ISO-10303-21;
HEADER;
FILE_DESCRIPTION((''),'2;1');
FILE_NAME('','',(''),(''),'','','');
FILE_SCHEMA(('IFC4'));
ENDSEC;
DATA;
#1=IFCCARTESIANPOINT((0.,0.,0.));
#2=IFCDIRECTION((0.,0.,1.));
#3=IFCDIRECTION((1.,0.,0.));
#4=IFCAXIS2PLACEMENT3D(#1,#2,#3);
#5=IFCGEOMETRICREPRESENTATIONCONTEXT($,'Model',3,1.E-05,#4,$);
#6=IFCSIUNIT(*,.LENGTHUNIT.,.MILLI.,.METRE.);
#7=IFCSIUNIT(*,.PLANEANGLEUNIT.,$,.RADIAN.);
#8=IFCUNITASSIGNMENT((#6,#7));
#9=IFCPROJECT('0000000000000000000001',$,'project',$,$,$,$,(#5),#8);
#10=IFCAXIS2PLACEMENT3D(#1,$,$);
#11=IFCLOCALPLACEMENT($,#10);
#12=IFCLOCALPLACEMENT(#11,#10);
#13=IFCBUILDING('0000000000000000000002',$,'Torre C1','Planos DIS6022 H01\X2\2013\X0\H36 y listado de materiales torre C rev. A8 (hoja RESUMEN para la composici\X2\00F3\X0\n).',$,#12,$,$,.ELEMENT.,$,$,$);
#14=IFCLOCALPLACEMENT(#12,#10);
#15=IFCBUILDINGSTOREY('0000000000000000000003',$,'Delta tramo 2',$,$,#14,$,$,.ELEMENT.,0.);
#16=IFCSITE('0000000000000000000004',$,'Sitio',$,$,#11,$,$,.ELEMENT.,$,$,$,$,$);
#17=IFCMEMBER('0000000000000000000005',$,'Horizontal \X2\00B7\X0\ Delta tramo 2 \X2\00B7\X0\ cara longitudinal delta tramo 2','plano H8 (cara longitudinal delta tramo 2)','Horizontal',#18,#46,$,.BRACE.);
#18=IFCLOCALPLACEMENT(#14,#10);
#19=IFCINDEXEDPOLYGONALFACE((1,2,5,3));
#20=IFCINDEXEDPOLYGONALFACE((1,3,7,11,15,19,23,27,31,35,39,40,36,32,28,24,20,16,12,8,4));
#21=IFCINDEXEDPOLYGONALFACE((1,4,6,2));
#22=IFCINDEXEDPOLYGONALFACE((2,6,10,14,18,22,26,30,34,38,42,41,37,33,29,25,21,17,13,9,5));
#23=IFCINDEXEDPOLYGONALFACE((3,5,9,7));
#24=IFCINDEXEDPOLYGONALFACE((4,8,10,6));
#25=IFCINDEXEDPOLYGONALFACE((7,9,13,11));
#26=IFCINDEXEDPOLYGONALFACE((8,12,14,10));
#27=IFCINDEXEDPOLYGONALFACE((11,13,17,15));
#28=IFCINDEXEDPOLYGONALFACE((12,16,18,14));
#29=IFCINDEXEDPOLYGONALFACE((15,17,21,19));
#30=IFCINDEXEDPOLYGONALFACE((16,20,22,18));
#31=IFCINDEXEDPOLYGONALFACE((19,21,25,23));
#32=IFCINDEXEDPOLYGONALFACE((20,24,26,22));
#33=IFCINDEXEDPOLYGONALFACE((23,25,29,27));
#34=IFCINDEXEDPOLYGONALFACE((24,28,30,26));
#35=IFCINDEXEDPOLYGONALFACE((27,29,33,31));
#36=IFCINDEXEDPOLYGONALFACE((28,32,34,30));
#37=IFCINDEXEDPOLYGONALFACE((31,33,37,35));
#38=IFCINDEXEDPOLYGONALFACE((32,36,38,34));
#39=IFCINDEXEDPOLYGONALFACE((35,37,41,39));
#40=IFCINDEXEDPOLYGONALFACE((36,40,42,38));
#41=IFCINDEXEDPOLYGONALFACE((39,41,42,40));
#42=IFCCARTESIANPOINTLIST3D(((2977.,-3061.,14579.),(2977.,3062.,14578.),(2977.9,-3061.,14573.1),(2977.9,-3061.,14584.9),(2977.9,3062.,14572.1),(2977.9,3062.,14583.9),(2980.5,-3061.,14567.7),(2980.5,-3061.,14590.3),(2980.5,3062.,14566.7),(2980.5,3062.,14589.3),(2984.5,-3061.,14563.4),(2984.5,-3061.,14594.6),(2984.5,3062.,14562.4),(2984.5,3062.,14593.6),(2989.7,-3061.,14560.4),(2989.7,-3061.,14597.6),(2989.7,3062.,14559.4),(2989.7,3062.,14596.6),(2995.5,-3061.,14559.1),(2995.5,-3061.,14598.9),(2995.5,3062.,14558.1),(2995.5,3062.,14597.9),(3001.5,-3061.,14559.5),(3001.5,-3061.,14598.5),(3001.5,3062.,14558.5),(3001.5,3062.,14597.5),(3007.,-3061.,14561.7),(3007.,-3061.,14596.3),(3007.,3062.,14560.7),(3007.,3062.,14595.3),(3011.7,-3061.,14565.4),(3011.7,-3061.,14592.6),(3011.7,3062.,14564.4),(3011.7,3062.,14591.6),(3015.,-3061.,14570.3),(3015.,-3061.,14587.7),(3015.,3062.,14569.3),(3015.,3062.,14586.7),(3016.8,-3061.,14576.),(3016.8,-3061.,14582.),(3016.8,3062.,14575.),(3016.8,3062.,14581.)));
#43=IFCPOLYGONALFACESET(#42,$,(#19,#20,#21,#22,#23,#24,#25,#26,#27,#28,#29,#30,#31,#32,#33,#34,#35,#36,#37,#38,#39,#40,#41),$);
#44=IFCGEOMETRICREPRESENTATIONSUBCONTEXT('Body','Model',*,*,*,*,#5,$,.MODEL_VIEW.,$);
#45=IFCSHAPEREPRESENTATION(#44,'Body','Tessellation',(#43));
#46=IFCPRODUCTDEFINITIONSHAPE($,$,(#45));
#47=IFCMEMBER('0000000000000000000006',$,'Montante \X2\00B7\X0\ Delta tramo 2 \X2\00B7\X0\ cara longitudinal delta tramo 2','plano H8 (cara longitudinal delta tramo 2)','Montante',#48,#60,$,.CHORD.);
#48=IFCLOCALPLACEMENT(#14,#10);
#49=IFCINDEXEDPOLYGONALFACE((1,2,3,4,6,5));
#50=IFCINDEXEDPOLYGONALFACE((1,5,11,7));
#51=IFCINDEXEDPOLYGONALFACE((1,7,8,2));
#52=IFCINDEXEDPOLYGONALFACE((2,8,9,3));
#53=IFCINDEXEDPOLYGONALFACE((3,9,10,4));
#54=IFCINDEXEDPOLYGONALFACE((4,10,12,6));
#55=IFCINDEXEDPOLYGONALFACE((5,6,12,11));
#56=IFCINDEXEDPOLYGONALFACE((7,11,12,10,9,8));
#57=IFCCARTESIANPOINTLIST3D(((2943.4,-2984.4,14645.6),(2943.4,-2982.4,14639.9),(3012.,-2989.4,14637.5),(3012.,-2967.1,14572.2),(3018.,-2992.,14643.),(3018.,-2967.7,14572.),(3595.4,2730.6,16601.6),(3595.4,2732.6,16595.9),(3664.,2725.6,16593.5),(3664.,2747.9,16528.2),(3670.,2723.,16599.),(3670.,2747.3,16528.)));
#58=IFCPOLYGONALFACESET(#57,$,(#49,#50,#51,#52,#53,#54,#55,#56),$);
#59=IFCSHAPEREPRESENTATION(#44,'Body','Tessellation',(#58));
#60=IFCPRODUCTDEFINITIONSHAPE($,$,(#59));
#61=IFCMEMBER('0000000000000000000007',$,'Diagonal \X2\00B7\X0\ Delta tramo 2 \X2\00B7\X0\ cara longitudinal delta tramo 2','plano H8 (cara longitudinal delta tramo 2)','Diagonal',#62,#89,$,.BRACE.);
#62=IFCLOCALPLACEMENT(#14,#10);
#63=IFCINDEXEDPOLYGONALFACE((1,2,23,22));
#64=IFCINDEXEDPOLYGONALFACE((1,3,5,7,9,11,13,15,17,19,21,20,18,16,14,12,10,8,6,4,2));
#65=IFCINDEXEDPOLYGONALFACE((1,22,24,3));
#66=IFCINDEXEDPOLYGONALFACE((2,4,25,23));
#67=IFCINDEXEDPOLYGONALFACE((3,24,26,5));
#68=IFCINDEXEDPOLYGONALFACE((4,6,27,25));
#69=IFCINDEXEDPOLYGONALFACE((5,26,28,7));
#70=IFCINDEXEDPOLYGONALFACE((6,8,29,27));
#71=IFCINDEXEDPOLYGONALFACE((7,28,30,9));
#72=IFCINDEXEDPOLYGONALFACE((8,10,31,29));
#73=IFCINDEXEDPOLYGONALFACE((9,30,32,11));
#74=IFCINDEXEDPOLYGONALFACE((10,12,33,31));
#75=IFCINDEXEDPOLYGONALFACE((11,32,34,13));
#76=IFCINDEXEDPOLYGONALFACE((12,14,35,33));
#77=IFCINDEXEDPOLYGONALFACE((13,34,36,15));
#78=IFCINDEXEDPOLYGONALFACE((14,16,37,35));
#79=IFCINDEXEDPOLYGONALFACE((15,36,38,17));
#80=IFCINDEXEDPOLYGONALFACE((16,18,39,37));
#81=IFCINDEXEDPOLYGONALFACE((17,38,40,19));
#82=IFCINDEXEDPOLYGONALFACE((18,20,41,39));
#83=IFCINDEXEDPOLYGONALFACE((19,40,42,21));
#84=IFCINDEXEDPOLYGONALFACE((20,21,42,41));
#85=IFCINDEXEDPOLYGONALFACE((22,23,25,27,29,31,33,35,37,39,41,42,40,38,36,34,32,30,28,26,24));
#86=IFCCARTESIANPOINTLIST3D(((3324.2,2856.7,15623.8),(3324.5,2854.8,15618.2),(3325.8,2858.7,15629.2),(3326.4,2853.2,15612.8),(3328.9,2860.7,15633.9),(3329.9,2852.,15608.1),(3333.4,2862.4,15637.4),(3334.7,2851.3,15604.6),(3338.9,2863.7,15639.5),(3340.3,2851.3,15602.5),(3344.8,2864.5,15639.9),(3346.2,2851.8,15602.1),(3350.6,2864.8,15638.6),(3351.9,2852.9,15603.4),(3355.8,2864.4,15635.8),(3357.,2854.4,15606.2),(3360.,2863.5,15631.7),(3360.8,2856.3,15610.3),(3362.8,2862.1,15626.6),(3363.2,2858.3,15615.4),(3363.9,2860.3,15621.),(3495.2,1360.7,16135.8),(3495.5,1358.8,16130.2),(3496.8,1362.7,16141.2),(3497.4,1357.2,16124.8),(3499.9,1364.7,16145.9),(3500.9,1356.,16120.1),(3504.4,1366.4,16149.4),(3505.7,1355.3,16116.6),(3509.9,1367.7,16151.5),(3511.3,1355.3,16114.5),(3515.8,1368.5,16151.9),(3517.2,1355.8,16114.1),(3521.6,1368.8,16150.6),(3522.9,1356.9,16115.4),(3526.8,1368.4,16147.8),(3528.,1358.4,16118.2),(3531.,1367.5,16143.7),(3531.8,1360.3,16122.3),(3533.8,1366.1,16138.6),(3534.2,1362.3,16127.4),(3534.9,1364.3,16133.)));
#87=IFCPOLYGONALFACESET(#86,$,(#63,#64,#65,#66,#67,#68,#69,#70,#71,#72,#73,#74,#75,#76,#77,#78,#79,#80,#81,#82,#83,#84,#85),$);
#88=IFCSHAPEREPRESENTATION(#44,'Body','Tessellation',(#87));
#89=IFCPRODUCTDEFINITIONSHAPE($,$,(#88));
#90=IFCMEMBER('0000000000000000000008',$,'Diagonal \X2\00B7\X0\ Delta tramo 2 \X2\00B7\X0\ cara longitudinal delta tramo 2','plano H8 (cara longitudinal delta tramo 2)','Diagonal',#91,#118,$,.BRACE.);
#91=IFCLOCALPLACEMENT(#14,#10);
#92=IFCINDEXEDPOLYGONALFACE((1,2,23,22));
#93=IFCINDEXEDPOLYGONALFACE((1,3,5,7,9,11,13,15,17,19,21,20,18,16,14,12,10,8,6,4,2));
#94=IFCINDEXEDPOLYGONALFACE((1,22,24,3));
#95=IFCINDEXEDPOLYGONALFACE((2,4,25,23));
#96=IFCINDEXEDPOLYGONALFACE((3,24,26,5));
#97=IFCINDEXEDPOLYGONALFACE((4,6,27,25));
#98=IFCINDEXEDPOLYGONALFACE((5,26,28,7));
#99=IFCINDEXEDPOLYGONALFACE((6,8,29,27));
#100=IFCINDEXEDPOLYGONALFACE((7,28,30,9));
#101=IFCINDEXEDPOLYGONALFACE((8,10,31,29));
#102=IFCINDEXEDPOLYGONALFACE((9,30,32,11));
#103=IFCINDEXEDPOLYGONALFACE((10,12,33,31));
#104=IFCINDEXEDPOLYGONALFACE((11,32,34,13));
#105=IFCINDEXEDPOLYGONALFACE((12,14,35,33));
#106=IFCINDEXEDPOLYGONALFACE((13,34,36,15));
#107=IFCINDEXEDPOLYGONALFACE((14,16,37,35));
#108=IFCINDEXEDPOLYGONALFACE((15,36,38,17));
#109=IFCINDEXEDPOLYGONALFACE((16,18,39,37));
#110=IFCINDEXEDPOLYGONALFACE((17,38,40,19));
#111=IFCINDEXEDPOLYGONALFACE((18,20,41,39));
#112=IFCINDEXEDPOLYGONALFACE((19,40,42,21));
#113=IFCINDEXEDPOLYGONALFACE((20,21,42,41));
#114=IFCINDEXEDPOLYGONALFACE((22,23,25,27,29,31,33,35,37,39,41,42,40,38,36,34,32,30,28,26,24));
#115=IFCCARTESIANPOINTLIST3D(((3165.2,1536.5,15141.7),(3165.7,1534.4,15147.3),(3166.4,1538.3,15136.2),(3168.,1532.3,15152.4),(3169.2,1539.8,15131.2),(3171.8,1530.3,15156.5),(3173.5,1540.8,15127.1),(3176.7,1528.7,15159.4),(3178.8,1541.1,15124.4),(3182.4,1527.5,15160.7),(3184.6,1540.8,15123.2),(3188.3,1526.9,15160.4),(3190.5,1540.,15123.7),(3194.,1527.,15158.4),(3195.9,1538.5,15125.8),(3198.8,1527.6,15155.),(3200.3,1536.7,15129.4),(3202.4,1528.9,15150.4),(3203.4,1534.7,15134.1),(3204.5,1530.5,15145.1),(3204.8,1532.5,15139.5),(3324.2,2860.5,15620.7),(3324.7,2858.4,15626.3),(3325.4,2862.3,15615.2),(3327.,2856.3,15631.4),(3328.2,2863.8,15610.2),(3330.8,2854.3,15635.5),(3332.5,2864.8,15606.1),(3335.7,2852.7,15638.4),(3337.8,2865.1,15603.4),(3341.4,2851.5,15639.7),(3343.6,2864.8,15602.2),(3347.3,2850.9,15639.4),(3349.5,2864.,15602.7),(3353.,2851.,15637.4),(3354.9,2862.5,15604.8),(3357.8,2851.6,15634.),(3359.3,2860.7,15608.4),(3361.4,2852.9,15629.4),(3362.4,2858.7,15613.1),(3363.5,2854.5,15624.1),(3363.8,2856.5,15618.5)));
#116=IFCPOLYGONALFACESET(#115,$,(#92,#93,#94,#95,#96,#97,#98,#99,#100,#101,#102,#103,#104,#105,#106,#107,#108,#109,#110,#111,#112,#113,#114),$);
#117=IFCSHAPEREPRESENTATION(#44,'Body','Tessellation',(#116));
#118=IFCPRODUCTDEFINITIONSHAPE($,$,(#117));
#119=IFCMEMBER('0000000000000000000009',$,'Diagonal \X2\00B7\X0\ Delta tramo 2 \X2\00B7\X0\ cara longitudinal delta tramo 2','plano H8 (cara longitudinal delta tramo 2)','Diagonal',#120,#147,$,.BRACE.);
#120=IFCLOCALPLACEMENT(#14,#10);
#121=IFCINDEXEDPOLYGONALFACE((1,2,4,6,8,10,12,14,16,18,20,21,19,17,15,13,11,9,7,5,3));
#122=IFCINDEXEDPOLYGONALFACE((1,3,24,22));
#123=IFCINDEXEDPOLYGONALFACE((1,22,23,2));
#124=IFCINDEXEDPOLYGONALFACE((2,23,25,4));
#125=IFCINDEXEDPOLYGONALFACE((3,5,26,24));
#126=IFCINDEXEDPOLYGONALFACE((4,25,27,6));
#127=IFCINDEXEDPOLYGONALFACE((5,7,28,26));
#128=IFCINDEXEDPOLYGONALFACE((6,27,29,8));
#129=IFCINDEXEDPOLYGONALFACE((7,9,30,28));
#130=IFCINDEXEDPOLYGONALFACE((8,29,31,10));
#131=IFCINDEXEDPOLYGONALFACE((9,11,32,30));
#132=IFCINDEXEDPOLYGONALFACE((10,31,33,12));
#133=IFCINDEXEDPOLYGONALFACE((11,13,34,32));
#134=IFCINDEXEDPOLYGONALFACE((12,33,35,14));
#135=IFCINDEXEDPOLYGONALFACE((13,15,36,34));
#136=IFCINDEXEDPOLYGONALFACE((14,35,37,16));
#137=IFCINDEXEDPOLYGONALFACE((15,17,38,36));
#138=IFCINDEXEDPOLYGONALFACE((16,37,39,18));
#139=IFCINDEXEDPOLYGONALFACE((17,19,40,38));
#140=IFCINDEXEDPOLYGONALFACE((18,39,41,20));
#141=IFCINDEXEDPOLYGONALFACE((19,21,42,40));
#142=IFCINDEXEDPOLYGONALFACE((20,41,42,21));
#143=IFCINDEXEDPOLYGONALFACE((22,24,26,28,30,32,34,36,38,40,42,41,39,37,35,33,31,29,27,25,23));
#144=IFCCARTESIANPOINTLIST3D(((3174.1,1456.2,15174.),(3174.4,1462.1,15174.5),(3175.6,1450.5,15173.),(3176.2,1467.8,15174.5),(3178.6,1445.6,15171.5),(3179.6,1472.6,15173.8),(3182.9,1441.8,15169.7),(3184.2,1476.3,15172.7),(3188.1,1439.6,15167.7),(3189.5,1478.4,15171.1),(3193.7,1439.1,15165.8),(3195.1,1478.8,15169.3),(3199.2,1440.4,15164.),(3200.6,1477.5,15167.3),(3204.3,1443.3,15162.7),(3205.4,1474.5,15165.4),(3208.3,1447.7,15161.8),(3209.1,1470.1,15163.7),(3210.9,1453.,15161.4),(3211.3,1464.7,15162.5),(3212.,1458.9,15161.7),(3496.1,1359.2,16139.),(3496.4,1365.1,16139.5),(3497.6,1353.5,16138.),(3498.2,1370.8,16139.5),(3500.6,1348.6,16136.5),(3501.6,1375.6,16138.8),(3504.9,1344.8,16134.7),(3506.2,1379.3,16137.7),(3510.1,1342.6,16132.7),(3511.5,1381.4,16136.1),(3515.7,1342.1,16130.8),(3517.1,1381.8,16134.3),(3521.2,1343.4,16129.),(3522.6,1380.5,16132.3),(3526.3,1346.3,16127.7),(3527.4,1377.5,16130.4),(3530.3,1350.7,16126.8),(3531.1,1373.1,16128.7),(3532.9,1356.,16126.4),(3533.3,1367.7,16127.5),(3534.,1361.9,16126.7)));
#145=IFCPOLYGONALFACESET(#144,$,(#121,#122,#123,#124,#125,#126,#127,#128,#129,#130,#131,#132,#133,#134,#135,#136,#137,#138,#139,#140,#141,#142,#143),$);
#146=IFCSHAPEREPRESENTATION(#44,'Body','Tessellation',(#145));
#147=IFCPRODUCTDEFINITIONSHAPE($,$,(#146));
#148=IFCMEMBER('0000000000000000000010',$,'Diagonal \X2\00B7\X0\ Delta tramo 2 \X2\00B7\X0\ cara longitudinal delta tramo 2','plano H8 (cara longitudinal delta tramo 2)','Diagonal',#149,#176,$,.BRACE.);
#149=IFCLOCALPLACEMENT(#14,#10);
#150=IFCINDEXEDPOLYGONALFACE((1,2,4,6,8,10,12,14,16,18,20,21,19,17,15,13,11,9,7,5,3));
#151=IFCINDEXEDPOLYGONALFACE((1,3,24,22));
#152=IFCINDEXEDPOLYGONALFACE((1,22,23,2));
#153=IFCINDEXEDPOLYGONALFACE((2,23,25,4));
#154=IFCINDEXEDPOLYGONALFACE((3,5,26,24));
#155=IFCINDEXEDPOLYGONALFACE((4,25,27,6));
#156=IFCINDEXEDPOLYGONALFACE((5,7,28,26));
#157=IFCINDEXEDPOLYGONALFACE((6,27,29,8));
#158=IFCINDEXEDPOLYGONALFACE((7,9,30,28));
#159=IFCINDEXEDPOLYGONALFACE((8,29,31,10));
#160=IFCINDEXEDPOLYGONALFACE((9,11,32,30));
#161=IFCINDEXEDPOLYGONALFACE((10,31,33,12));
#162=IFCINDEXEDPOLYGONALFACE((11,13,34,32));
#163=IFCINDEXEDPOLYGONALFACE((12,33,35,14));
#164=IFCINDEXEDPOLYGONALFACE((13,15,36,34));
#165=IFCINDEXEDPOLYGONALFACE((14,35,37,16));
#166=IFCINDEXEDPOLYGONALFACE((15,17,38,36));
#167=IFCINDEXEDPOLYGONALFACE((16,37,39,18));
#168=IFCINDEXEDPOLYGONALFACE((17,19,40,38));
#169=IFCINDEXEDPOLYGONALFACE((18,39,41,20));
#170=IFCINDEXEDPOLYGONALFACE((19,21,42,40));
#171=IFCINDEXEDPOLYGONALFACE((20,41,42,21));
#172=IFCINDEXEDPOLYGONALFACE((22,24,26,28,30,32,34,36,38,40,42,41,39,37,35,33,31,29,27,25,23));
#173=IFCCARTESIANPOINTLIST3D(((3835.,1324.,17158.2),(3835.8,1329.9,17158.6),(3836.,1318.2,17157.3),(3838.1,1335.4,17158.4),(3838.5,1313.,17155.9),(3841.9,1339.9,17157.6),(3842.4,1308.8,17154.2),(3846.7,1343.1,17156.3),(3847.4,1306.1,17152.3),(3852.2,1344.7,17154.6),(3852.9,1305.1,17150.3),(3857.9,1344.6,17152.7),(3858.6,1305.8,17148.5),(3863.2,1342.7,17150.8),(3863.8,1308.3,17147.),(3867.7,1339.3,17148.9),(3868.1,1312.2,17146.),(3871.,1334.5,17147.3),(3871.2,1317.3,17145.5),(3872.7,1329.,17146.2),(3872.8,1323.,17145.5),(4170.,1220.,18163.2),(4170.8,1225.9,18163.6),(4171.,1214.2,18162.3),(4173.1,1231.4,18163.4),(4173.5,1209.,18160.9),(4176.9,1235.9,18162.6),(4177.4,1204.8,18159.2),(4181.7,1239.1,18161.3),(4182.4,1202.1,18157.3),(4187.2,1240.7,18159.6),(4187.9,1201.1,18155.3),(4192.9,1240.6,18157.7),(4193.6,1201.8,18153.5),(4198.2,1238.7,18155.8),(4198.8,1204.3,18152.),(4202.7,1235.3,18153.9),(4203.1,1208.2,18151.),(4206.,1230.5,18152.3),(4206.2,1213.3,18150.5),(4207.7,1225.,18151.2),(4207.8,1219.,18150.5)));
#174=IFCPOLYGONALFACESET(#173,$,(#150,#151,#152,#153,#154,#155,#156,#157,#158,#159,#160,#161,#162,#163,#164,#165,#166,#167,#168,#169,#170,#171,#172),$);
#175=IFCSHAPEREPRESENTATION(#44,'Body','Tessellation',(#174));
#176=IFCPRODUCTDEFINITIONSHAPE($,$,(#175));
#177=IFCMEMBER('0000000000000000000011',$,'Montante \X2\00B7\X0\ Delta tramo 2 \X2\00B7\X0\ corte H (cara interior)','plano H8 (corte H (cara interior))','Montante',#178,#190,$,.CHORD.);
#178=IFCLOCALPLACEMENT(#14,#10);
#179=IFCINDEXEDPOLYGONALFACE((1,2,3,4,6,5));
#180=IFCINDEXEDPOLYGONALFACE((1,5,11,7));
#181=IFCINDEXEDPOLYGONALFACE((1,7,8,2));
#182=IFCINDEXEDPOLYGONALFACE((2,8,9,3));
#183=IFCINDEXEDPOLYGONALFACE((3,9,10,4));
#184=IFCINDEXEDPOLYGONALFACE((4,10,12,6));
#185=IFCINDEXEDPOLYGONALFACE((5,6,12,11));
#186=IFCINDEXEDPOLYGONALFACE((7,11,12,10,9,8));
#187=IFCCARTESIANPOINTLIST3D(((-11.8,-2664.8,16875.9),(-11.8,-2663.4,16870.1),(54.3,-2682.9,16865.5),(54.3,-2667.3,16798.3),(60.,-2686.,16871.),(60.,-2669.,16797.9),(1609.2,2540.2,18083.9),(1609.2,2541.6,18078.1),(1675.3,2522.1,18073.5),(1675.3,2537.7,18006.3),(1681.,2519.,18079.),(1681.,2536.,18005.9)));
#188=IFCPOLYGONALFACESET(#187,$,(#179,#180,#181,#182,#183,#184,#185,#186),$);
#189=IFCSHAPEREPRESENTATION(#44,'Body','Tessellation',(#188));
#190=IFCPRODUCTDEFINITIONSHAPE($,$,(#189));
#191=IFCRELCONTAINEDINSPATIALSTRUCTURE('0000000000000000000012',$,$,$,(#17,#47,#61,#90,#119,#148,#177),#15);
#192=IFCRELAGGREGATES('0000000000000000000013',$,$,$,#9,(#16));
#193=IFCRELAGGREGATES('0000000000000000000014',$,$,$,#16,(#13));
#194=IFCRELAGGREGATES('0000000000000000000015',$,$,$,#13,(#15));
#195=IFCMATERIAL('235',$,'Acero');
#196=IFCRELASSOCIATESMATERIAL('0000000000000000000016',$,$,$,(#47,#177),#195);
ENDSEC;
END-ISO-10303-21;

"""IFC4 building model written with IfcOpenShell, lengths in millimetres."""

from ifc_helpers import new_model, si_unit, frame, frame_2d, origin, origin_with_axes, place, context, subcontext, project, spatial, circle, l_section, extrude, material, element, save


model = new_model("IFC4")

# Units and contexts
model_context = context("Model", 3, precision=1e-05, world=origin_with_axes())
body_context = subcontext(model_context, "Body", "Model", "MODEL_VIEW")
ifc_project = project(units=[si_unit("LENGTHUNIT", "METRE", prefix="MILLI"), si_unit("PLANEANGLEUNIT", "RADIAN")], contexts=[model_context])

# Site, building, storey
site_placement = place(None, origin())
site = spatial("IfcSite", under=ifc_project, at=site_placement, Name="Sitio", CompositionType="ELEMENT")
building_placement = place(site_placement, origin())
building = spatial("IfcBuilding", under=site, at=building_placement, Name="Torre C1", Description="Planos DIS6022 H01–H36 y listado de materiales torre C rev. A8 (hoja RESUMEN para la composición).", CompositionType="ELEMENT")
storey_placement = place(building_placement, origin())
storey = spatial("IfcBuildingStorey", under=building, at=storey_placement, Name="Delta tramo 2", CompositionType="ELEMENT", Elevation=0.0)

# Members
member_1_placement = place(storey_placement, frame((2997.0, 3062.0, 14578.0), z_axis=(0.0, -1.0, 0.000163), x_axis=(-1.0, 0.0, 0.0)))
element("IfcMember", 1, at=member_1_placement, inside=storey, Name="Horizontal · Delta tramo 2 · cara longitudinal delta tramo 2", Description="plano H8 (cara longitudinal delta tramo 2)", ObjectType="Horizontal", PredefinedType="BRACE", context=body_context, shape_type="SweptSolid", body=[
    extrude(circle(Radius=20.0), None, (0.0, 0.0, 1.0), 6123.0),
])
ifc_material_1 = material(Name="235", Category="Acero")
member_2_placement = place(storey_placement, frame((3670.0, 2723.0, 16599.0), z_axis=(-0.107315, -0.940656, -0.321946), x_axis=(-0.994225, 0.101533, 0.034751)))
element("IfcMember", 2, at=member_2_placement, inside=storey, material=ifc_material_1, Name="Montante · Delta tramo 2 · cara longitudinal delta tramo 2", Description="plano H8 (cara longitudinal delta tramo 2)", ObjectType="Montante", PredefinedType="CHORD", context=body_context, shape_type="SweptSolid", body=[
    extrude(l_section(Depth=75.0, Width=75.0, Thickness=6.0, at=frame_2d((37.5, 37.5))), None, (0.0, 0.0, 1.0), 6075.5),
])
member_3_placement = place(storey_placement, frame((3515.0, 1362.0, 16133.0), z_axis=(-0.10752, 0.940639, -0.32193), x_axis=(-0.976994, -0.159952, -0.141059)))
element("IfcMember", 3, at=member_3_placement, inside=storey, Name="Diagonal · Delta tramo 2 · cara longitudinal delta tramo 2", Description="plano H8 (cara longitudinal delta tramo 2)", ObjectType="Diagonal", PredefinedType="BRACE", context=body_context, shape_type="SweptSolid", body=[
    extrude(circle(Radius=20.0), None, (0.0, 0.0, 1.0), 1590.4),
])
member_4_placement = place(storey_placement, frame((3344.0, 2858.0, 15621.0), z_axis=(-0.112214, -0.934413, -0.338054), x_axis=(-0.964462, 0.020521, 0.263423)))
element("IfcMember", 4, at=member_4_placement, inside=storey, Name="Diagonal · Delta tramo 2 · cara longitudinal delta tramo 2", Description="plano H8 (cara longitudinal delta tramo 2)", ObjectType="Diagonal", PredefinedType="BRACE", context=body_context, shape_type="SweptSolid", body=[
    extrude(circle(Radius=20.0), None, (0.0, 0.0, 1.0), 1416.9),
])
member_5_placement = place(storey_placement, frame((3515.0, 1362.0, 16133.0), z_axis=(-0.315094, 0.094919, -0.944302), x_axis=(-0.870343, -0.425656, 0.247629)))
element("IfcMember", 5, at=member_5_placement, inside=storey, Name="Diagonal · Delta tramo 2 · cara longitudinal delta tramo 2", Description="plano H8 (cara longitudinal delta tramo 2)", ObjectType="Diagonal", PredefinedType="BRACE", context=body_context, shape_type="SweptSolid", body=[
    extrude(circle(Radius=20.0), None, (0.0, 0.0, 1.0), 1021.9),
])
member_6_placement = place(storey_placement, frame((3854.0, 1325.0, 17152.0), z_axis=(0.314715, -0.097703, 0.944144), x_axis=(-0.901862, -0.340939, 0.26534)))
element("IfcMember", 6, at=member_6_placement, inside=storey, Name="Diagonal · Delta tramo 2 · cara longitudinal delta tramo 2", Description="plano H8 (cara longitudinal delta tramo 2)", ObjectType="Diagonal", PredefinedType="BRACE", context=body_context, shape_type="SweptSolid", body=[
    extrude(circle(Radius=20.0), None, (0.0, 0.0, 1.0), 1064.5),
])
member_7_placement = place(storey_placement, frame((1681.0, 2519.0, 18079.0), z_axis=(-0.290304, -0.932159, -0.21634), x_axis=(-0.956935, 0.282788, 0.065631)))
element("IfcMember", 7, at=member_7_placement, inside=storey, material=ifc_material_1, Name="Montante · Delta tramo 2 · corte H (cara interior)", Description="plano H8 (corte H (cara interior))", ObjectType="Montante", PredefinedType="CHORD", context=body_context, shape_type="SweptSolid", body=[
    extrude(l_section(Depth=75.0, Width=75.0, Thickness=6.0, at=frame_2d((37.5, 37.5))), None, (0.0, 0.0, 1.0), 5583.8),
])

save(model, "model.ifc")
